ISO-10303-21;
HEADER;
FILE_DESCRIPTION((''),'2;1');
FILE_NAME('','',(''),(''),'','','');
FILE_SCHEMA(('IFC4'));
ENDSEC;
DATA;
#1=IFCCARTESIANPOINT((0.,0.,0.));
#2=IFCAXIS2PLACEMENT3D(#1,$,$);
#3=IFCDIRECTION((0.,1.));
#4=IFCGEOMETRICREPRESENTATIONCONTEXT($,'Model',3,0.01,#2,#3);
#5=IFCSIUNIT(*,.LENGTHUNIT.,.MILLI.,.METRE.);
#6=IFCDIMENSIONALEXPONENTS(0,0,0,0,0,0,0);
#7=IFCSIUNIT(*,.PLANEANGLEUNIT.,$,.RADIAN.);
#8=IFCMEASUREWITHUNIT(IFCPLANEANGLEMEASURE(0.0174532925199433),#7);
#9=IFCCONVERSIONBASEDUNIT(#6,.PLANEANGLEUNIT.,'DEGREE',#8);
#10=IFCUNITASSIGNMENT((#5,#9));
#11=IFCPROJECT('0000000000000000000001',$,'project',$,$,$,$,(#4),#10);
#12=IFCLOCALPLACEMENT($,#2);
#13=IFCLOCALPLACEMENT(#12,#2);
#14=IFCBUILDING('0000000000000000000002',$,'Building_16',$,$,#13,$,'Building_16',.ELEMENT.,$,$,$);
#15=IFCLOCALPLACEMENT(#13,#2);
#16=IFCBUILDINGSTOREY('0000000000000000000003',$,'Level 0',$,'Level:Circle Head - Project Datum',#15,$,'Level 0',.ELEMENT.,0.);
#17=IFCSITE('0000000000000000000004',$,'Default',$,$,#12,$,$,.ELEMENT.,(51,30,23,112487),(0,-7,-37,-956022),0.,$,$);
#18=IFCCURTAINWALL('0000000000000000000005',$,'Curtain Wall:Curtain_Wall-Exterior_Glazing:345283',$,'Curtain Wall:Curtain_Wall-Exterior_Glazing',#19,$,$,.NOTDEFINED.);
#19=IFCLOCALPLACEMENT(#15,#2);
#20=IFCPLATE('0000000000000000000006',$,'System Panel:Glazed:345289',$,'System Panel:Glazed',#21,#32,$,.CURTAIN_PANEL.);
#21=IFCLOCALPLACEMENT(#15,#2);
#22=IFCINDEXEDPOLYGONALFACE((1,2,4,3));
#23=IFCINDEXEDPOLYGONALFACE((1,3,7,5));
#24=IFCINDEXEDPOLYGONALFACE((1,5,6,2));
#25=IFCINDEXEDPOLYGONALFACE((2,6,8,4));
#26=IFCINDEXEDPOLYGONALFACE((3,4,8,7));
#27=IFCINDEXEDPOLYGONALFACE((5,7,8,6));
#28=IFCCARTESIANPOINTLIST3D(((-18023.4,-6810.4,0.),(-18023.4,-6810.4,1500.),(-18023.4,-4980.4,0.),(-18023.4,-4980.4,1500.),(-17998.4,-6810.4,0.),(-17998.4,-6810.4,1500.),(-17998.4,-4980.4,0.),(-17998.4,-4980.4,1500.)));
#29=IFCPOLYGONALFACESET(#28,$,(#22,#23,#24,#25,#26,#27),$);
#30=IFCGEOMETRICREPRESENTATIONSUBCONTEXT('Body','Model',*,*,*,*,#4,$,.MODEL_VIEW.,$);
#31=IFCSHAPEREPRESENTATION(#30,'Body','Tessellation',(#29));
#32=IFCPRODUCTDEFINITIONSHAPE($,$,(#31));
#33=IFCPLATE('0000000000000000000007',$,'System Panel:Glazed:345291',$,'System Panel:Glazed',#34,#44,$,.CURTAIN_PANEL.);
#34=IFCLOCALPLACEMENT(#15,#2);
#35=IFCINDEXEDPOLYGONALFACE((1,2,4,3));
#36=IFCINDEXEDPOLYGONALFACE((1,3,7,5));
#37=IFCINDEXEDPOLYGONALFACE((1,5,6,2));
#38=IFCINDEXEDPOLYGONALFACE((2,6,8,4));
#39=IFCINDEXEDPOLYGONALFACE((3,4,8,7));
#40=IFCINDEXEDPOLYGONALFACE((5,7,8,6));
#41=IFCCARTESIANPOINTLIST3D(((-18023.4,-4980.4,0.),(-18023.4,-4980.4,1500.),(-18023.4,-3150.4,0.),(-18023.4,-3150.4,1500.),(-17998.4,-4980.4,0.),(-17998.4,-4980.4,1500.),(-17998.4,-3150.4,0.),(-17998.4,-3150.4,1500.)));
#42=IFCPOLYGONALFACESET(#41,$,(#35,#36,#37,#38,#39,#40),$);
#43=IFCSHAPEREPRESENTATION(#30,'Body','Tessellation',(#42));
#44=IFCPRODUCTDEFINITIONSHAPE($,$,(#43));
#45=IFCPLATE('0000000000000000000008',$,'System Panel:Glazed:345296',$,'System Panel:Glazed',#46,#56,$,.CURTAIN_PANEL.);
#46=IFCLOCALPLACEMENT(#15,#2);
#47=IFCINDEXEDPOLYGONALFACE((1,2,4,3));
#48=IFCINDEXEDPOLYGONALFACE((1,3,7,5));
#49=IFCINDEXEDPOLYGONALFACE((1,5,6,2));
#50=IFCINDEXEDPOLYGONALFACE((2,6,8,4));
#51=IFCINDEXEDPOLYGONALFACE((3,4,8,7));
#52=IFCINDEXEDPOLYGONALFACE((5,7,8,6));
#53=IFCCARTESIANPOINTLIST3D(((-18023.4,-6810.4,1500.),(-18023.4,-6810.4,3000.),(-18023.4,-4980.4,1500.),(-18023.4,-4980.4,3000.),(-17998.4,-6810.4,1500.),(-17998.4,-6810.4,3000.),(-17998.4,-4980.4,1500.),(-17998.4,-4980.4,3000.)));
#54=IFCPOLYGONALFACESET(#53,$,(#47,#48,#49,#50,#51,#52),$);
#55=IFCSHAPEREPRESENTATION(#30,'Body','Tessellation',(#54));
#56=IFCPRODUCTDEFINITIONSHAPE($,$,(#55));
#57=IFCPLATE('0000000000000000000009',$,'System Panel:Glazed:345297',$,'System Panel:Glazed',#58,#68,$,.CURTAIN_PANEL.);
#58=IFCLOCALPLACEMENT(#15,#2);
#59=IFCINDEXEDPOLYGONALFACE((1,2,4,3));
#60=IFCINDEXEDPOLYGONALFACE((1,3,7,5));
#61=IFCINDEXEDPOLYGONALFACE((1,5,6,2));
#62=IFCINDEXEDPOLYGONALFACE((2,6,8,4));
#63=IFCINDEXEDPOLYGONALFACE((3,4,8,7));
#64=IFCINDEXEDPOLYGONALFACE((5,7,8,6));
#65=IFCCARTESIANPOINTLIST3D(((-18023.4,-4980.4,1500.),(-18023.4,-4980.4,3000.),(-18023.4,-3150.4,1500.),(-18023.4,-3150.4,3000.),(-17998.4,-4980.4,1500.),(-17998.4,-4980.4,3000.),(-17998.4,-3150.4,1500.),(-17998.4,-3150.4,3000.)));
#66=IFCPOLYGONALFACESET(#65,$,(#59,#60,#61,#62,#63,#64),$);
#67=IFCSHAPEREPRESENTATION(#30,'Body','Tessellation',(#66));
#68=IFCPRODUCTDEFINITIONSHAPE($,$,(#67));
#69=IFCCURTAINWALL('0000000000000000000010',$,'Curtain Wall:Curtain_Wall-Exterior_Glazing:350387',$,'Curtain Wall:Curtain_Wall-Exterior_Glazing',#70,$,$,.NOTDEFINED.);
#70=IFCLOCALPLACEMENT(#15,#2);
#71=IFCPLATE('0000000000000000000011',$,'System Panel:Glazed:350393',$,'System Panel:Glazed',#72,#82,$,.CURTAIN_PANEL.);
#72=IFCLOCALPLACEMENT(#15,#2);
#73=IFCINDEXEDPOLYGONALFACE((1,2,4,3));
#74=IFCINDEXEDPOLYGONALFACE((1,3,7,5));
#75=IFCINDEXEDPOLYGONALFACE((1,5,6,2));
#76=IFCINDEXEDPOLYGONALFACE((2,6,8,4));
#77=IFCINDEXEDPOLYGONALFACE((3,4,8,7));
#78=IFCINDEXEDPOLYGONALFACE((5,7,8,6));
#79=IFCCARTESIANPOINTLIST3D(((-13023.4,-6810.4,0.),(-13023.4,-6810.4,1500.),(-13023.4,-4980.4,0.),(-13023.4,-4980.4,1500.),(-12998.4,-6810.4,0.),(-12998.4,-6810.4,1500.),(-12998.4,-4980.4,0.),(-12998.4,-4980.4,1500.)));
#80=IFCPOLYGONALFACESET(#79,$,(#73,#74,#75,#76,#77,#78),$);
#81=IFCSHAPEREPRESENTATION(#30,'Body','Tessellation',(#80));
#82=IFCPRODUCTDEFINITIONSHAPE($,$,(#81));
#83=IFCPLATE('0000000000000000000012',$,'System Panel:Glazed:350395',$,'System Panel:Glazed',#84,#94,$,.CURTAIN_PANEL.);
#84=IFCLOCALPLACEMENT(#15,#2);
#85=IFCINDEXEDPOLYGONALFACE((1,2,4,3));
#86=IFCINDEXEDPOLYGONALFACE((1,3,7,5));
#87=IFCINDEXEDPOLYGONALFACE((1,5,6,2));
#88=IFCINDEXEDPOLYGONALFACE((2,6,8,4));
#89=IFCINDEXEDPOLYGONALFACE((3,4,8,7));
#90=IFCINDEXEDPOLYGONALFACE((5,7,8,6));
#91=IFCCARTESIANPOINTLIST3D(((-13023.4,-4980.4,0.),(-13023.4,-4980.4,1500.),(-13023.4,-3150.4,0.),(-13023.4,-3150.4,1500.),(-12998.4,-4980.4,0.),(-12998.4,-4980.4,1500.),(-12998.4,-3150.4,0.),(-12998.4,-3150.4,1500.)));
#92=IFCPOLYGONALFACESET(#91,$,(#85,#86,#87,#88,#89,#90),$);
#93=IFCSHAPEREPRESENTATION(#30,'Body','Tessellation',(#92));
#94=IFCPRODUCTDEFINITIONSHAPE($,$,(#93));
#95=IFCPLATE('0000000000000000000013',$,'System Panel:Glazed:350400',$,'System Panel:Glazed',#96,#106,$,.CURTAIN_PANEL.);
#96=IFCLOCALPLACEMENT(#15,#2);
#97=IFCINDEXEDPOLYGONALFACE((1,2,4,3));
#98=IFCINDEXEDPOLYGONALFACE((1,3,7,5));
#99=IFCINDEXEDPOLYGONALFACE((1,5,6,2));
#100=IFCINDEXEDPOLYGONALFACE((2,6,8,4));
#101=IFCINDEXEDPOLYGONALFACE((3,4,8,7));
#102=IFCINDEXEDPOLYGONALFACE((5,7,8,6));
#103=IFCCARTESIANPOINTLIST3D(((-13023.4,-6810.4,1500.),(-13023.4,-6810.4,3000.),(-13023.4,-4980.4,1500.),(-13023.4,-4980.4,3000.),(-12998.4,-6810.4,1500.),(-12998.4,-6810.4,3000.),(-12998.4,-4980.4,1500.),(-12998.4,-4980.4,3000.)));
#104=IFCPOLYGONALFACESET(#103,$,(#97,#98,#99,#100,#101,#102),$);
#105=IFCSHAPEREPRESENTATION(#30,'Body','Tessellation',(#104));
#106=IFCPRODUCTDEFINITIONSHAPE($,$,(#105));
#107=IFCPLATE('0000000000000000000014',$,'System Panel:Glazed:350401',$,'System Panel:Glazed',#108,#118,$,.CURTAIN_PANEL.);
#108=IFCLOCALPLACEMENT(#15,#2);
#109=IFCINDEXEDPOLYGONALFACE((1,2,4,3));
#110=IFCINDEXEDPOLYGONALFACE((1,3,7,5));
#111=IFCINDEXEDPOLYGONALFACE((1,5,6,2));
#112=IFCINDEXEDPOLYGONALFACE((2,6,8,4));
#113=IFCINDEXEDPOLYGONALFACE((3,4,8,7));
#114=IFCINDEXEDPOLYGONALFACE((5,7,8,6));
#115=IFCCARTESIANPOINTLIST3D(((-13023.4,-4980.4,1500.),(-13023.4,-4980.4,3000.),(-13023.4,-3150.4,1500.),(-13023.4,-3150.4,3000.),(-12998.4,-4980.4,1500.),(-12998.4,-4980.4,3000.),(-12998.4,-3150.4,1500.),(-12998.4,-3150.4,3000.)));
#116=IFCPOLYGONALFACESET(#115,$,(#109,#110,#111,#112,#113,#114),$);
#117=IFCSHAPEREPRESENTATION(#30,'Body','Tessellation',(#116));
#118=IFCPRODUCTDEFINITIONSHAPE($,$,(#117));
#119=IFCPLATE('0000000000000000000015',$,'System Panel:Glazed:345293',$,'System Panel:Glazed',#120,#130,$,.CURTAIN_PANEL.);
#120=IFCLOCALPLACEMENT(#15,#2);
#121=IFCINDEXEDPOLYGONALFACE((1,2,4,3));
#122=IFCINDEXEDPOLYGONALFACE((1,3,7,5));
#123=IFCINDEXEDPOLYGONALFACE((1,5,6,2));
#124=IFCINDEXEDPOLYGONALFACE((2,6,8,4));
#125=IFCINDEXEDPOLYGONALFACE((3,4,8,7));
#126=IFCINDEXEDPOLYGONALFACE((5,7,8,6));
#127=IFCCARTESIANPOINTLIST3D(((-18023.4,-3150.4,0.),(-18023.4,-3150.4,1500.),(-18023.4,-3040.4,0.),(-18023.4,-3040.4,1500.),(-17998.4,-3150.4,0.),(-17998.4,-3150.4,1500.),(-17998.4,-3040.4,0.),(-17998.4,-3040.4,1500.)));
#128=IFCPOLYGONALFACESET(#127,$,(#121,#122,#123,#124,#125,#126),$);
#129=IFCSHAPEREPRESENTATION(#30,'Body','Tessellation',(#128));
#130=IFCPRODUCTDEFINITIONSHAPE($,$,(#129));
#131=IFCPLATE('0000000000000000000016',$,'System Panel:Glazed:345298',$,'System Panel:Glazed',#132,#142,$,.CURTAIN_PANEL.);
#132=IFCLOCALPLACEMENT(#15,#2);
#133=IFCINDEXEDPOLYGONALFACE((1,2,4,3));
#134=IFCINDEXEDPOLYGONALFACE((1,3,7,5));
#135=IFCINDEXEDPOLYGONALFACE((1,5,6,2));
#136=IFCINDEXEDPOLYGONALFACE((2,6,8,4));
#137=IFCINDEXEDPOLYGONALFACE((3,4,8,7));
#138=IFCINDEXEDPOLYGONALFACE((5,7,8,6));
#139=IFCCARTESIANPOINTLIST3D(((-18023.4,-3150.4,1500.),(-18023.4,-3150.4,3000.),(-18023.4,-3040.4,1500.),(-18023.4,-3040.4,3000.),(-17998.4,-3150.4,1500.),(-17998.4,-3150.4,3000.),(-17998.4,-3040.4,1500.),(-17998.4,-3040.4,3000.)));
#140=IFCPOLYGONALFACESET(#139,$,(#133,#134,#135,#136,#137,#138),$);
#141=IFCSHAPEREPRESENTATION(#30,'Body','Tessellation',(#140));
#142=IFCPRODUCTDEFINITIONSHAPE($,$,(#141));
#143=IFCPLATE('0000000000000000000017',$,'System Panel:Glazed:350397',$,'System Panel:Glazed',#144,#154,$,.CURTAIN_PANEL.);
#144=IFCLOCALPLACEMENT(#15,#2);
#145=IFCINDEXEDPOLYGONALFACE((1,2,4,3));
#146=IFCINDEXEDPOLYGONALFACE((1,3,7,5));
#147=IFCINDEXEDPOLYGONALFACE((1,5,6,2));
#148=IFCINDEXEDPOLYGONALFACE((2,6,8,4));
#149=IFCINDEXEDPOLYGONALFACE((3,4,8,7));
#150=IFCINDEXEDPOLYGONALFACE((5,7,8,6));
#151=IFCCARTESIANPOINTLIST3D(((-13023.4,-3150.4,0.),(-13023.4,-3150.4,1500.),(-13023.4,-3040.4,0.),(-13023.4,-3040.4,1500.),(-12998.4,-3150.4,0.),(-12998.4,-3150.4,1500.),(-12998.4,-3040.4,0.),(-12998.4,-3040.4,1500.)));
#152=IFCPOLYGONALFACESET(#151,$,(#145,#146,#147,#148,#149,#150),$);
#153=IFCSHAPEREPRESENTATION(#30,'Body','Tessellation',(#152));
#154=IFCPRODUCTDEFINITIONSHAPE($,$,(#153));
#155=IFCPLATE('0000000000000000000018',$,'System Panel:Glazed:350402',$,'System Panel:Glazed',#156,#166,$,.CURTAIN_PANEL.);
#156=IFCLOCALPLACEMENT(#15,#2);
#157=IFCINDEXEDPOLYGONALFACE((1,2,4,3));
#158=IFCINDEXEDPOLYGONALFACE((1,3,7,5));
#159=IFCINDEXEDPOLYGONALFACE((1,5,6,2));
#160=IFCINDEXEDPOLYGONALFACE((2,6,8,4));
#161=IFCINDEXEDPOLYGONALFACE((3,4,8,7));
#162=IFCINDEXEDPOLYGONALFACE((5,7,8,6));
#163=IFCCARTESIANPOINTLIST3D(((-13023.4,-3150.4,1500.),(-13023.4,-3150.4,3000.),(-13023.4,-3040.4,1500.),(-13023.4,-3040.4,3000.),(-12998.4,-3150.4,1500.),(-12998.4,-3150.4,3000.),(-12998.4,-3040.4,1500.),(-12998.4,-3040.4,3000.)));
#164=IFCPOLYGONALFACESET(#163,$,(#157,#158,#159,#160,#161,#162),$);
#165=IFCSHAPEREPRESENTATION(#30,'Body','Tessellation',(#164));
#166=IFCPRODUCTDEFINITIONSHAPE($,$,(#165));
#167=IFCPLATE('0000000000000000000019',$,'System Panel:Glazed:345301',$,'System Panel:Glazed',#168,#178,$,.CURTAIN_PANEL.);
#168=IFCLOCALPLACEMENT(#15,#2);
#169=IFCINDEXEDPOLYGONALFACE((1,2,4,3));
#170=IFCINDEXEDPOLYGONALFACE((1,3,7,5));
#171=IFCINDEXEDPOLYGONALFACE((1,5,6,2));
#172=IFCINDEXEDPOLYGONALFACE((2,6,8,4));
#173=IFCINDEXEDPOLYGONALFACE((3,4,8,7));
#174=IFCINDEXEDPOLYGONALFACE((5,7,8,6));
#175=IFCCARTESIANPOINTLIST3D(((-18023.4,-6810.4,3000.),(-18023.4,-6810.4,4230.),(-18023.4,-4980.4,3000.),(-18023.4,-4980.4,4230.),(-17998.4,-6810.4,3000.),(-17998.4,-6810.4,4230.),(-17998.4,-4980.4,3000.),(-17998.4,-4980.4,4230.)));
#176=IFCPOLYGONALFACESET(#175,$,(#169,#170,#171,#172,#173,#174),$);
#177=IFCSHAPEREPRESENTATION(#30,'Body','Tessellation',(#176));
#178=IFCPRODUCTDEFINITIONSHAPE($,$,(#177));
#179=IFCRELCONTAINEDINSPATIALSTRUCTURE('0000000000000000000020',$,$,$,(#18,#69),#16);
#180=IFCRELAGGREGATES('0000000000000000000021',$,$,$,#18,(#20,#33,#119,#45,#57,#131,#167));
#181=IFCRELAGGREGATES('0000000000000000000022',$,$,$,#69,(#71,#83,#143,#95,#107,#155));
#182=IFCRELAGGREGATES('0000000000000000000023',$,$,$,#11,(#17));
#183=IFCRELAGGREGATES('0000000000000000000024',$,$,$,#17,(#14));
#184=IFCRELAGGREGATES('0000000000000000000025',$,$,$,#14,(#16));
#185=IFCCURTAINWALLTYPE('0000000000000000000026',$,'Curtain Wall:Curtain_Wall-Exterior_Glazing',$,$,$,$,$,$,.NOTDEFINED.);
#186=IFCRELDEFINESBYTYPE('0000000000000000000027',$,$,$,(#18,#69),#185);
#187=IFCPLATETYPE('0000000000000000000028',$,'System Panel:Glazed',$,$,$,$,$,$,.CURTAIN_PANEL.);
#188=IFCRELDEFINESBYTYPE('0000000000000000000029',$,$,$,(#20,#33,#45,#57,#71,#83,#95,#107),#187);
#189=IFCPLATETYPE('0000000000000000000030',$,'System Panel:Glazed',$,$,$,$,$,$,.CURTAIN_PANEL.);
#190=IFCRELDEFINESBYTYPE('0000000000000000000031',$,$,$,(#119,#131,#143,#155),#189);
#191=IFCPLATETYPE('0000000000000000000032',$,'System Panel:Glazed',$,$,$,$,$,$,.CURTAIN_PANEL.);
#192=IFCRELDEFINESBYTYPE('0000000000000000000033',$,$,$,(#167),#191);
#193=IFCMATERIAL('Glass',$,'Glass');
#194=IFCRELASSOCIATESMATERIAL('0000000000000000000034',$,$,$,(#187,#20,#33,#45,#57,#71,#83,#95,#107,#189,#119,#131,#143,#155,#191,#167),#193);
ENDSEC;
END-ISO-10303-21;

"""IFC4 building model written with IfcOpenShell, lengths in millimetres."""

from ifc_helpers import new_model, entity, si_unit, converted_unit, direction, frame, origin, place, context, subcontext, project, spatial, indexed_curve, outline, extrude, source, transform, mapped, material, type_object, type_shapes, element, aggregate, save


model = new_model("IFC4")

# Units and contexts
model_context = context("Model", 3, precision=0.01, world=origin(), true_north=direction((0.0, 1.0)))
body_context = subcontext(model_context, "Body", "Model", "MODEL_VIEW")
ifc_project = project(units=[si_unit("LENGTHUNIT", "METRE", prefix="MILLI"), converted_unit("PLANEANGLEUNIT", "DEGREE", entity("IfcPlaneAngleMeasure", 0.0174532925199433), si_unit("PLANEANGLEUNIT", "RADIAN"), dimensions=[0, 0, 0, 0, 0, 0, 0])], contexts=[model_context])

# Site, building, storey
site_placement = place(None, origin())
site = spatial("IfcSite", under=ifc_project, at=site_placement, Name="Default", CompositionType="ELEMENT", RefLatitude=(51, 30, 23, 112487), RefLongitude=(0, -7, -37, -956022), RefElevation=0.0)
building_placement = place(site_placement, origin())
building = spatial("IfcBuilding", under=site, at=building_placement, Name="Building_16", LongName="Building_16", CompositionType="ELEMENT")
storey_placement = place(building_placement, origin())
storey = spatial("IfcBuildingStorey", under=building, at=storey_placement, Name="Level 0", ObjectType="Level:Circle Head - Project Datum", LongName="Level 0", CompositionType="ELEMENT", Elevation=0.0)

# Curtain walls, plates
curtain_wall_type = type_object("IfcCurtainWallType", Name="Curtain Wall:Curtain_Wall-Exterior_Glazing", PredefinedType="NOTDEFINED")
curtain_wall_1_placement = place(storey_placement, origin())
curtain_wall_1 = element("IfcCurtainWall", 1, at=curtain_wall_1_placement, inside=storey, type_object=curtain_wall_type, Name="Curtain Wall:Curtain_Wall-Exterior_Glazing:345283", ObjectType="Curtain Wall:Curtain_Wall-Exterior_Glazing", PredefinedType="NOTDEFINED")
ifc_material_1 = material(Name="Glass", Category="Glass")
plate_type_1 = type_object("IfcPlateType", Name="System Panel:Glazed", PredefinedType="CURTAIN_PANEL", material=ifc_material_1)
shared_shape_1 = source(origin(), body_context, "Body", "SweptSolid", [
    extrude(outline(indexed_curve([(-12.5, -915.0), (12.5, -915.0), (12.5, 915.0), (-12.5, 915.0), (-12.5, -915.0)], self_intersect=False)), frame((0.0, 37.0, 0.0), z_axis=(0.0, 0.0, 1.0), x_axis=(0.0, 1.0, 0.0)), (0.0, 0.0, 1.0), 1500.0),
])
type_shapes(plate_type_1, [shared_shape_1])
plate_1_placement = place(curtain_wall_1_placement, frame((-17973.9, -5895.4, 0.0), z_axis=(0.0, 0.0, 1.0), x_axis=(0.0, 1.0, 0.0)))
plate_1 = element("IfcPlate", 2, at=plate_1_placement, type_object=plate_type_1, material=ifc_material_1, Name="System Panel:Glazed:345289", ObjectType="System Panel:Glazed", PredefinedType="CURTAIN_PANEL", context=body_context, shape_type="MappedRepresentation", body=[
    mapped(shared_shape_1, transform((0.0, 0.0, 0.0), scale=1.0)),
])
plate_2_placement = place(curtain_wall_1_placement, frame((-17973.9, -4065.4, 0.0), z_axis=(0.0, 0.0, 1.0), x_axis=(0.0, 1.0, 0.0)))
plate_2 = element("IfcPlate", 3, at=plate_2_placement, type_object=plate_type_1, material=ifc_material_1, Name="System Panel:Glazed:345291", ObjectType="System Panel:Glazed", PredefinedType="CURTAIN_PANEL", context=body_context, shape_type="MappedRepresentation", body=[
    mapped(shared_shape_1, transform((0.0, 0.0, 0.0), scale=1.0)),
])
plate_3_placement = place(curtain_wall_1_placement, frame((-17973.9, -5895.4, 1500.0), z_axis=(0.0, 0.0, 1.0), x_axis=(0.0, 1.0, 0.0)))
plate_3 = element("IfcPlate", 4, at=plate_3_placement, type_object=plate_type_1, material=ifc_material_1, Name="System Panel:Glazed:345296", ObjectType="System Panel:Glazed", PredefinedType="CURTAIN_PANEL", context=body_context, shape_type="MappedRepresentation", body=[
    mapped(shared_shape_1, transform((0.0, 0.0, 0.0), scale=1.0)),
])
plate_4_placement = place(curtain_wall_1_placement, frame((-17973.9, -4065.4, 1500.0), z_axis=(0.0, 0.0, 1.0), x_axis=(0.0, 1.0, 0.0)))
plate_4 = element("IfcPlate", 5, at=plate_4_placement, type_object=plate_type_1, material=ifc_material_1, Name="System Panel:Glazed:345297", ObjectType="System Panel:Glazed", PredefinedType="CURTAIN_PANEL", context=body_context, shape_type="MappedRepresentation", body=[
    mapped(shared_shape_1, transform((0.0, 0.0, 0.0), scale=1.0)),
])
curtain_wall_2_placement = place(storey_placement, origin())
curtain_wall_2 = element("IfcCurtainWall", 6, at=curtain_wall_2_placement, inside=storey, type_object=curtain_wall_type, Name="Curtain Wall:Curtain_Wall-Exterior_Glazing:350387", ObjectType="Curtain Wall:Curtain_Wall-Exterior_Glazing", PredefinedType="NOTDEFINED")
plate_5_placement = place(curtain_wall_2_placement, frame((-12973.9, -5895.4, 0.0), z_axis=(0.0, 0.0, 1.0), x_axis=(0.0, 1.0, 0.0)))
plate_5 = element("IfcPlate", 7, at=plate_5_placement, type_object=plate_type_1, material=ifc_material_1, Name="System Panel:Glazed:350393", ObjectType="System Panel:Glazed", PredefinedType="CURTAIN_PANEL", context=body_context, shape_type="MappedRepresentation", body=[
    mapped(shared_shape_1, transform((0.0, 0.0, 0.0), scale=1.0)),
])
plate_6_placement = place(curtain_wall_2_placement, frame((-12973.9, -4065.4, 0.0), z_axis=(0.0, 0.0, 1.0), x_axis=(0.0, 1.0, 0.0)))
plate_6 = element("IfcPlate", 8, at=plate_6_placement, type_object=plate_type_1, material=ifc_material_1, Name="System Panel:Glazed:350395", ObjectType="System Panel:Glazed", PredefinedType="CURTAIN_PANEL", context=body_context, shape_type="MappedRepresentation", body=[
    mapped(shared_shape_1, transform((0.0, 0.0, 0.0), scale=1.0)),
])
plate_7_placement = place(curtain_wall_2_placement, frame((-12973.9, -5895.4, 1500.0), z_axis=(0.0, 0.0, 1.0), x_axis=(0.0, 1.0, 0.0)))
plate_7 = element("IfcPlate", 9, at=plate_7_placement, type_object=plate_type_1, material=ifc_material_1, Name="System Panel:Glazed:350400", ObjectType="System Panel:Glazed", PredefinedType="CURTAIN_PANEL", context=body_context, shape_type="MappedRepresentation", body=[
    mapped(shared_shape_1, transform((0.0, 0.0, 0.0), scale=1.0)),
])
plate_8_placement = place(curtain_wall_2_placement, frame((-12973.9, -4065.4, 1500.0), z_axis=(0.0, 0.0, 1.0), x_axis=(0.0, 1.0, 0.0)))
plate_8 = element("IfcPlate", 10, at=plate_8_placement, type_object=plate_type_1, material=ifc_material_1, Name="System Panel:Glazed:350401", ObjectType="System Panel:Glazed", PredefinedType="CURTAIN_PANEL", context=body_context, shape_type="MappedRepresentation", body=[
    mapped(shared_shape_1, transform((0.0, 0.0, 0.0), scale=1.0)),
])

# Plates
plate_type_2 = type_object("IfcPlateType", Name="System Panel:Glazed", PredefinedType="CURTAIN_PANEL", material=ifc_material_1)
shared_shape_2 = source(origin(), body_context, "Body", "SweptSolid", [
    extrude(outline(indexed_curve([(-12.5, -55.0), (12.5, -55.0), (12.5, 55.0), (-12.5, 55.0), (-12.5, -55.0)], self_intersect=False)), frame((0.0, 37.0, 0.0), z_axis=(0.0, 0.0, 1.0), x_axis=(0.0, 1.0, 0.0)), (0.0, 0.0, 1.0), 1500.0),
])
type_shapes(plate_type_2, [shared_shape_2])
plate_9_placement = place(curtain_wall_1_placement, frame((-17973.9, -3095.4, 0.0), z_axis=(0.0, 0.0, 1.0), x_axis=(0.0, 1.0, 0.0)))
plate_9 = element("IfcPlate", 11, at=plate_9_placement, type_object=plate_type_2, material=ifc_material_1, Name="System Panel:Glazed:345293", ObjectType="System Panel:Glazed", PredefinedType="CURTAIN_PANEL", context=body_context, shape_type="MappedRepresentation", body=[
    mapped(shared_shape_2, transform((0.0, 0.0, 0.0), scale=1.0)),
])
plate_10_placement = place(curtain_wall_1_placement, frame((-17973.9, -3095.4, 1500.0), z_axis=(0.0, 0.0, 1.0), x_axis=(0.0, 1.0, 0.0)))
plate_10 = element("IfcPlate", 12, at=plate_10_placement, type_object=plate_type_2, material=ifc_material_1, Name="System Panel:Glazed:345298", ObjectType="System Panel:Glazed", PredefinedType="CURTAIN_PANEL", context=body_context, shape_type="MappedRepresentation", body=[
    mapped(shared_shape_2, transform((0.0, 0.0, 0.0), scale=1.0)),
])
plate_11_placement = place(curtain_wall_2_placement, frame((-12973.9, -3095.4, 0.0), z_axis=(0.0, 0.0, 1.0), x_axis=(0.0, 1.0, 0.0)))
plate_11 = element("IfcPlate", 13, at=plate_11_placement, type_object=plate_type_2, material=ifc_material_1, Name="System Panel:Glazed:350397", ObjectType="System Panel:Glazed", PredefinedType="CURTAIN_PANEL", context=body_context, shape_type="MappedRepresentation", body=[
    mapped(shared_shape_2, transform((0.0, 0.0, 0.0), scale=1.0)),
])
plate_12_placement = place(curtain_wall_2_placement, frame((-12973.9, -3095.4, 1500.0), z_axis=(0.0, 0.0, 1.0), x_axis=(0.0, 1.0, 0.0)))
plate_12 = element("IfcPlate", 14, at=plate_12_placement, type_object=plate_type_2, material=ifc_material_1, Name="System Panel:Glazed:350402", ObjectType="System Panel:Glazed", PredefinedType="CURTAIN_PANEL", context=body_context, shape_type="MappedRepresentation", body=[
    mapped(shared_shape_2, transform((0.0, 0.0, 0.0), scale=1.0)),
])
plate_type_3 = type_object("IfcPlateType", Name="System Panel:Glazed", PredefinedType="CURTAIN_PANEL", material=ifc_material_1)
shared_shape_3 = source(origin(), body_context, "Body", "SweptSolid", [
    extrude(outline(indexed_curve([(-12.5, -915.0), (12.5, -915.0), (12.5, 915.0), (-12.5, 915.0), (-12.5, -915.0)], self_intersect=False)), frame((0.0, 37.0, 0.0), z_axis=(0.0, 0.0, 1.0), x_axis=(0.0, 1.0, 0.0)), (0.0, 0.0, 1.0), 1230.0),
])
type_shapes(plate_type_3, [shared_shape_3])
plate_13_placement = place(curtain_wall_1_placement, frame((-17973.9, -5895.4, 3000.0), z_axis=(0.0, 0.0, 1.0), x_axis=(0.0, 1.0, 0.0)))
plate_13 = element("IfcPlate", 15, at=plate_13_placement, type_object=plate_type_3, material=ifc_material_1, Name="System Panel:Glazed:345301", ObjectType="System Panel:Glazed", PredefinedType="CURTAIN_PANEL", context=body_context, shape_type="MappedRepresentation", body=[
    mapped(shared_shape_3, transform((0.0, 0.0, 0.0), scale=1.0)),
])
aggregate(curtain_wall_1, [plate_1, plate_2, plate_9, plate_3, plate_4, plate_10, plate_13])
aggregate(curtain_wall_2, [plate_5, plate_6, plate_11, plate_7, plate_8, plate_12])

save(model, "model.ifc")
